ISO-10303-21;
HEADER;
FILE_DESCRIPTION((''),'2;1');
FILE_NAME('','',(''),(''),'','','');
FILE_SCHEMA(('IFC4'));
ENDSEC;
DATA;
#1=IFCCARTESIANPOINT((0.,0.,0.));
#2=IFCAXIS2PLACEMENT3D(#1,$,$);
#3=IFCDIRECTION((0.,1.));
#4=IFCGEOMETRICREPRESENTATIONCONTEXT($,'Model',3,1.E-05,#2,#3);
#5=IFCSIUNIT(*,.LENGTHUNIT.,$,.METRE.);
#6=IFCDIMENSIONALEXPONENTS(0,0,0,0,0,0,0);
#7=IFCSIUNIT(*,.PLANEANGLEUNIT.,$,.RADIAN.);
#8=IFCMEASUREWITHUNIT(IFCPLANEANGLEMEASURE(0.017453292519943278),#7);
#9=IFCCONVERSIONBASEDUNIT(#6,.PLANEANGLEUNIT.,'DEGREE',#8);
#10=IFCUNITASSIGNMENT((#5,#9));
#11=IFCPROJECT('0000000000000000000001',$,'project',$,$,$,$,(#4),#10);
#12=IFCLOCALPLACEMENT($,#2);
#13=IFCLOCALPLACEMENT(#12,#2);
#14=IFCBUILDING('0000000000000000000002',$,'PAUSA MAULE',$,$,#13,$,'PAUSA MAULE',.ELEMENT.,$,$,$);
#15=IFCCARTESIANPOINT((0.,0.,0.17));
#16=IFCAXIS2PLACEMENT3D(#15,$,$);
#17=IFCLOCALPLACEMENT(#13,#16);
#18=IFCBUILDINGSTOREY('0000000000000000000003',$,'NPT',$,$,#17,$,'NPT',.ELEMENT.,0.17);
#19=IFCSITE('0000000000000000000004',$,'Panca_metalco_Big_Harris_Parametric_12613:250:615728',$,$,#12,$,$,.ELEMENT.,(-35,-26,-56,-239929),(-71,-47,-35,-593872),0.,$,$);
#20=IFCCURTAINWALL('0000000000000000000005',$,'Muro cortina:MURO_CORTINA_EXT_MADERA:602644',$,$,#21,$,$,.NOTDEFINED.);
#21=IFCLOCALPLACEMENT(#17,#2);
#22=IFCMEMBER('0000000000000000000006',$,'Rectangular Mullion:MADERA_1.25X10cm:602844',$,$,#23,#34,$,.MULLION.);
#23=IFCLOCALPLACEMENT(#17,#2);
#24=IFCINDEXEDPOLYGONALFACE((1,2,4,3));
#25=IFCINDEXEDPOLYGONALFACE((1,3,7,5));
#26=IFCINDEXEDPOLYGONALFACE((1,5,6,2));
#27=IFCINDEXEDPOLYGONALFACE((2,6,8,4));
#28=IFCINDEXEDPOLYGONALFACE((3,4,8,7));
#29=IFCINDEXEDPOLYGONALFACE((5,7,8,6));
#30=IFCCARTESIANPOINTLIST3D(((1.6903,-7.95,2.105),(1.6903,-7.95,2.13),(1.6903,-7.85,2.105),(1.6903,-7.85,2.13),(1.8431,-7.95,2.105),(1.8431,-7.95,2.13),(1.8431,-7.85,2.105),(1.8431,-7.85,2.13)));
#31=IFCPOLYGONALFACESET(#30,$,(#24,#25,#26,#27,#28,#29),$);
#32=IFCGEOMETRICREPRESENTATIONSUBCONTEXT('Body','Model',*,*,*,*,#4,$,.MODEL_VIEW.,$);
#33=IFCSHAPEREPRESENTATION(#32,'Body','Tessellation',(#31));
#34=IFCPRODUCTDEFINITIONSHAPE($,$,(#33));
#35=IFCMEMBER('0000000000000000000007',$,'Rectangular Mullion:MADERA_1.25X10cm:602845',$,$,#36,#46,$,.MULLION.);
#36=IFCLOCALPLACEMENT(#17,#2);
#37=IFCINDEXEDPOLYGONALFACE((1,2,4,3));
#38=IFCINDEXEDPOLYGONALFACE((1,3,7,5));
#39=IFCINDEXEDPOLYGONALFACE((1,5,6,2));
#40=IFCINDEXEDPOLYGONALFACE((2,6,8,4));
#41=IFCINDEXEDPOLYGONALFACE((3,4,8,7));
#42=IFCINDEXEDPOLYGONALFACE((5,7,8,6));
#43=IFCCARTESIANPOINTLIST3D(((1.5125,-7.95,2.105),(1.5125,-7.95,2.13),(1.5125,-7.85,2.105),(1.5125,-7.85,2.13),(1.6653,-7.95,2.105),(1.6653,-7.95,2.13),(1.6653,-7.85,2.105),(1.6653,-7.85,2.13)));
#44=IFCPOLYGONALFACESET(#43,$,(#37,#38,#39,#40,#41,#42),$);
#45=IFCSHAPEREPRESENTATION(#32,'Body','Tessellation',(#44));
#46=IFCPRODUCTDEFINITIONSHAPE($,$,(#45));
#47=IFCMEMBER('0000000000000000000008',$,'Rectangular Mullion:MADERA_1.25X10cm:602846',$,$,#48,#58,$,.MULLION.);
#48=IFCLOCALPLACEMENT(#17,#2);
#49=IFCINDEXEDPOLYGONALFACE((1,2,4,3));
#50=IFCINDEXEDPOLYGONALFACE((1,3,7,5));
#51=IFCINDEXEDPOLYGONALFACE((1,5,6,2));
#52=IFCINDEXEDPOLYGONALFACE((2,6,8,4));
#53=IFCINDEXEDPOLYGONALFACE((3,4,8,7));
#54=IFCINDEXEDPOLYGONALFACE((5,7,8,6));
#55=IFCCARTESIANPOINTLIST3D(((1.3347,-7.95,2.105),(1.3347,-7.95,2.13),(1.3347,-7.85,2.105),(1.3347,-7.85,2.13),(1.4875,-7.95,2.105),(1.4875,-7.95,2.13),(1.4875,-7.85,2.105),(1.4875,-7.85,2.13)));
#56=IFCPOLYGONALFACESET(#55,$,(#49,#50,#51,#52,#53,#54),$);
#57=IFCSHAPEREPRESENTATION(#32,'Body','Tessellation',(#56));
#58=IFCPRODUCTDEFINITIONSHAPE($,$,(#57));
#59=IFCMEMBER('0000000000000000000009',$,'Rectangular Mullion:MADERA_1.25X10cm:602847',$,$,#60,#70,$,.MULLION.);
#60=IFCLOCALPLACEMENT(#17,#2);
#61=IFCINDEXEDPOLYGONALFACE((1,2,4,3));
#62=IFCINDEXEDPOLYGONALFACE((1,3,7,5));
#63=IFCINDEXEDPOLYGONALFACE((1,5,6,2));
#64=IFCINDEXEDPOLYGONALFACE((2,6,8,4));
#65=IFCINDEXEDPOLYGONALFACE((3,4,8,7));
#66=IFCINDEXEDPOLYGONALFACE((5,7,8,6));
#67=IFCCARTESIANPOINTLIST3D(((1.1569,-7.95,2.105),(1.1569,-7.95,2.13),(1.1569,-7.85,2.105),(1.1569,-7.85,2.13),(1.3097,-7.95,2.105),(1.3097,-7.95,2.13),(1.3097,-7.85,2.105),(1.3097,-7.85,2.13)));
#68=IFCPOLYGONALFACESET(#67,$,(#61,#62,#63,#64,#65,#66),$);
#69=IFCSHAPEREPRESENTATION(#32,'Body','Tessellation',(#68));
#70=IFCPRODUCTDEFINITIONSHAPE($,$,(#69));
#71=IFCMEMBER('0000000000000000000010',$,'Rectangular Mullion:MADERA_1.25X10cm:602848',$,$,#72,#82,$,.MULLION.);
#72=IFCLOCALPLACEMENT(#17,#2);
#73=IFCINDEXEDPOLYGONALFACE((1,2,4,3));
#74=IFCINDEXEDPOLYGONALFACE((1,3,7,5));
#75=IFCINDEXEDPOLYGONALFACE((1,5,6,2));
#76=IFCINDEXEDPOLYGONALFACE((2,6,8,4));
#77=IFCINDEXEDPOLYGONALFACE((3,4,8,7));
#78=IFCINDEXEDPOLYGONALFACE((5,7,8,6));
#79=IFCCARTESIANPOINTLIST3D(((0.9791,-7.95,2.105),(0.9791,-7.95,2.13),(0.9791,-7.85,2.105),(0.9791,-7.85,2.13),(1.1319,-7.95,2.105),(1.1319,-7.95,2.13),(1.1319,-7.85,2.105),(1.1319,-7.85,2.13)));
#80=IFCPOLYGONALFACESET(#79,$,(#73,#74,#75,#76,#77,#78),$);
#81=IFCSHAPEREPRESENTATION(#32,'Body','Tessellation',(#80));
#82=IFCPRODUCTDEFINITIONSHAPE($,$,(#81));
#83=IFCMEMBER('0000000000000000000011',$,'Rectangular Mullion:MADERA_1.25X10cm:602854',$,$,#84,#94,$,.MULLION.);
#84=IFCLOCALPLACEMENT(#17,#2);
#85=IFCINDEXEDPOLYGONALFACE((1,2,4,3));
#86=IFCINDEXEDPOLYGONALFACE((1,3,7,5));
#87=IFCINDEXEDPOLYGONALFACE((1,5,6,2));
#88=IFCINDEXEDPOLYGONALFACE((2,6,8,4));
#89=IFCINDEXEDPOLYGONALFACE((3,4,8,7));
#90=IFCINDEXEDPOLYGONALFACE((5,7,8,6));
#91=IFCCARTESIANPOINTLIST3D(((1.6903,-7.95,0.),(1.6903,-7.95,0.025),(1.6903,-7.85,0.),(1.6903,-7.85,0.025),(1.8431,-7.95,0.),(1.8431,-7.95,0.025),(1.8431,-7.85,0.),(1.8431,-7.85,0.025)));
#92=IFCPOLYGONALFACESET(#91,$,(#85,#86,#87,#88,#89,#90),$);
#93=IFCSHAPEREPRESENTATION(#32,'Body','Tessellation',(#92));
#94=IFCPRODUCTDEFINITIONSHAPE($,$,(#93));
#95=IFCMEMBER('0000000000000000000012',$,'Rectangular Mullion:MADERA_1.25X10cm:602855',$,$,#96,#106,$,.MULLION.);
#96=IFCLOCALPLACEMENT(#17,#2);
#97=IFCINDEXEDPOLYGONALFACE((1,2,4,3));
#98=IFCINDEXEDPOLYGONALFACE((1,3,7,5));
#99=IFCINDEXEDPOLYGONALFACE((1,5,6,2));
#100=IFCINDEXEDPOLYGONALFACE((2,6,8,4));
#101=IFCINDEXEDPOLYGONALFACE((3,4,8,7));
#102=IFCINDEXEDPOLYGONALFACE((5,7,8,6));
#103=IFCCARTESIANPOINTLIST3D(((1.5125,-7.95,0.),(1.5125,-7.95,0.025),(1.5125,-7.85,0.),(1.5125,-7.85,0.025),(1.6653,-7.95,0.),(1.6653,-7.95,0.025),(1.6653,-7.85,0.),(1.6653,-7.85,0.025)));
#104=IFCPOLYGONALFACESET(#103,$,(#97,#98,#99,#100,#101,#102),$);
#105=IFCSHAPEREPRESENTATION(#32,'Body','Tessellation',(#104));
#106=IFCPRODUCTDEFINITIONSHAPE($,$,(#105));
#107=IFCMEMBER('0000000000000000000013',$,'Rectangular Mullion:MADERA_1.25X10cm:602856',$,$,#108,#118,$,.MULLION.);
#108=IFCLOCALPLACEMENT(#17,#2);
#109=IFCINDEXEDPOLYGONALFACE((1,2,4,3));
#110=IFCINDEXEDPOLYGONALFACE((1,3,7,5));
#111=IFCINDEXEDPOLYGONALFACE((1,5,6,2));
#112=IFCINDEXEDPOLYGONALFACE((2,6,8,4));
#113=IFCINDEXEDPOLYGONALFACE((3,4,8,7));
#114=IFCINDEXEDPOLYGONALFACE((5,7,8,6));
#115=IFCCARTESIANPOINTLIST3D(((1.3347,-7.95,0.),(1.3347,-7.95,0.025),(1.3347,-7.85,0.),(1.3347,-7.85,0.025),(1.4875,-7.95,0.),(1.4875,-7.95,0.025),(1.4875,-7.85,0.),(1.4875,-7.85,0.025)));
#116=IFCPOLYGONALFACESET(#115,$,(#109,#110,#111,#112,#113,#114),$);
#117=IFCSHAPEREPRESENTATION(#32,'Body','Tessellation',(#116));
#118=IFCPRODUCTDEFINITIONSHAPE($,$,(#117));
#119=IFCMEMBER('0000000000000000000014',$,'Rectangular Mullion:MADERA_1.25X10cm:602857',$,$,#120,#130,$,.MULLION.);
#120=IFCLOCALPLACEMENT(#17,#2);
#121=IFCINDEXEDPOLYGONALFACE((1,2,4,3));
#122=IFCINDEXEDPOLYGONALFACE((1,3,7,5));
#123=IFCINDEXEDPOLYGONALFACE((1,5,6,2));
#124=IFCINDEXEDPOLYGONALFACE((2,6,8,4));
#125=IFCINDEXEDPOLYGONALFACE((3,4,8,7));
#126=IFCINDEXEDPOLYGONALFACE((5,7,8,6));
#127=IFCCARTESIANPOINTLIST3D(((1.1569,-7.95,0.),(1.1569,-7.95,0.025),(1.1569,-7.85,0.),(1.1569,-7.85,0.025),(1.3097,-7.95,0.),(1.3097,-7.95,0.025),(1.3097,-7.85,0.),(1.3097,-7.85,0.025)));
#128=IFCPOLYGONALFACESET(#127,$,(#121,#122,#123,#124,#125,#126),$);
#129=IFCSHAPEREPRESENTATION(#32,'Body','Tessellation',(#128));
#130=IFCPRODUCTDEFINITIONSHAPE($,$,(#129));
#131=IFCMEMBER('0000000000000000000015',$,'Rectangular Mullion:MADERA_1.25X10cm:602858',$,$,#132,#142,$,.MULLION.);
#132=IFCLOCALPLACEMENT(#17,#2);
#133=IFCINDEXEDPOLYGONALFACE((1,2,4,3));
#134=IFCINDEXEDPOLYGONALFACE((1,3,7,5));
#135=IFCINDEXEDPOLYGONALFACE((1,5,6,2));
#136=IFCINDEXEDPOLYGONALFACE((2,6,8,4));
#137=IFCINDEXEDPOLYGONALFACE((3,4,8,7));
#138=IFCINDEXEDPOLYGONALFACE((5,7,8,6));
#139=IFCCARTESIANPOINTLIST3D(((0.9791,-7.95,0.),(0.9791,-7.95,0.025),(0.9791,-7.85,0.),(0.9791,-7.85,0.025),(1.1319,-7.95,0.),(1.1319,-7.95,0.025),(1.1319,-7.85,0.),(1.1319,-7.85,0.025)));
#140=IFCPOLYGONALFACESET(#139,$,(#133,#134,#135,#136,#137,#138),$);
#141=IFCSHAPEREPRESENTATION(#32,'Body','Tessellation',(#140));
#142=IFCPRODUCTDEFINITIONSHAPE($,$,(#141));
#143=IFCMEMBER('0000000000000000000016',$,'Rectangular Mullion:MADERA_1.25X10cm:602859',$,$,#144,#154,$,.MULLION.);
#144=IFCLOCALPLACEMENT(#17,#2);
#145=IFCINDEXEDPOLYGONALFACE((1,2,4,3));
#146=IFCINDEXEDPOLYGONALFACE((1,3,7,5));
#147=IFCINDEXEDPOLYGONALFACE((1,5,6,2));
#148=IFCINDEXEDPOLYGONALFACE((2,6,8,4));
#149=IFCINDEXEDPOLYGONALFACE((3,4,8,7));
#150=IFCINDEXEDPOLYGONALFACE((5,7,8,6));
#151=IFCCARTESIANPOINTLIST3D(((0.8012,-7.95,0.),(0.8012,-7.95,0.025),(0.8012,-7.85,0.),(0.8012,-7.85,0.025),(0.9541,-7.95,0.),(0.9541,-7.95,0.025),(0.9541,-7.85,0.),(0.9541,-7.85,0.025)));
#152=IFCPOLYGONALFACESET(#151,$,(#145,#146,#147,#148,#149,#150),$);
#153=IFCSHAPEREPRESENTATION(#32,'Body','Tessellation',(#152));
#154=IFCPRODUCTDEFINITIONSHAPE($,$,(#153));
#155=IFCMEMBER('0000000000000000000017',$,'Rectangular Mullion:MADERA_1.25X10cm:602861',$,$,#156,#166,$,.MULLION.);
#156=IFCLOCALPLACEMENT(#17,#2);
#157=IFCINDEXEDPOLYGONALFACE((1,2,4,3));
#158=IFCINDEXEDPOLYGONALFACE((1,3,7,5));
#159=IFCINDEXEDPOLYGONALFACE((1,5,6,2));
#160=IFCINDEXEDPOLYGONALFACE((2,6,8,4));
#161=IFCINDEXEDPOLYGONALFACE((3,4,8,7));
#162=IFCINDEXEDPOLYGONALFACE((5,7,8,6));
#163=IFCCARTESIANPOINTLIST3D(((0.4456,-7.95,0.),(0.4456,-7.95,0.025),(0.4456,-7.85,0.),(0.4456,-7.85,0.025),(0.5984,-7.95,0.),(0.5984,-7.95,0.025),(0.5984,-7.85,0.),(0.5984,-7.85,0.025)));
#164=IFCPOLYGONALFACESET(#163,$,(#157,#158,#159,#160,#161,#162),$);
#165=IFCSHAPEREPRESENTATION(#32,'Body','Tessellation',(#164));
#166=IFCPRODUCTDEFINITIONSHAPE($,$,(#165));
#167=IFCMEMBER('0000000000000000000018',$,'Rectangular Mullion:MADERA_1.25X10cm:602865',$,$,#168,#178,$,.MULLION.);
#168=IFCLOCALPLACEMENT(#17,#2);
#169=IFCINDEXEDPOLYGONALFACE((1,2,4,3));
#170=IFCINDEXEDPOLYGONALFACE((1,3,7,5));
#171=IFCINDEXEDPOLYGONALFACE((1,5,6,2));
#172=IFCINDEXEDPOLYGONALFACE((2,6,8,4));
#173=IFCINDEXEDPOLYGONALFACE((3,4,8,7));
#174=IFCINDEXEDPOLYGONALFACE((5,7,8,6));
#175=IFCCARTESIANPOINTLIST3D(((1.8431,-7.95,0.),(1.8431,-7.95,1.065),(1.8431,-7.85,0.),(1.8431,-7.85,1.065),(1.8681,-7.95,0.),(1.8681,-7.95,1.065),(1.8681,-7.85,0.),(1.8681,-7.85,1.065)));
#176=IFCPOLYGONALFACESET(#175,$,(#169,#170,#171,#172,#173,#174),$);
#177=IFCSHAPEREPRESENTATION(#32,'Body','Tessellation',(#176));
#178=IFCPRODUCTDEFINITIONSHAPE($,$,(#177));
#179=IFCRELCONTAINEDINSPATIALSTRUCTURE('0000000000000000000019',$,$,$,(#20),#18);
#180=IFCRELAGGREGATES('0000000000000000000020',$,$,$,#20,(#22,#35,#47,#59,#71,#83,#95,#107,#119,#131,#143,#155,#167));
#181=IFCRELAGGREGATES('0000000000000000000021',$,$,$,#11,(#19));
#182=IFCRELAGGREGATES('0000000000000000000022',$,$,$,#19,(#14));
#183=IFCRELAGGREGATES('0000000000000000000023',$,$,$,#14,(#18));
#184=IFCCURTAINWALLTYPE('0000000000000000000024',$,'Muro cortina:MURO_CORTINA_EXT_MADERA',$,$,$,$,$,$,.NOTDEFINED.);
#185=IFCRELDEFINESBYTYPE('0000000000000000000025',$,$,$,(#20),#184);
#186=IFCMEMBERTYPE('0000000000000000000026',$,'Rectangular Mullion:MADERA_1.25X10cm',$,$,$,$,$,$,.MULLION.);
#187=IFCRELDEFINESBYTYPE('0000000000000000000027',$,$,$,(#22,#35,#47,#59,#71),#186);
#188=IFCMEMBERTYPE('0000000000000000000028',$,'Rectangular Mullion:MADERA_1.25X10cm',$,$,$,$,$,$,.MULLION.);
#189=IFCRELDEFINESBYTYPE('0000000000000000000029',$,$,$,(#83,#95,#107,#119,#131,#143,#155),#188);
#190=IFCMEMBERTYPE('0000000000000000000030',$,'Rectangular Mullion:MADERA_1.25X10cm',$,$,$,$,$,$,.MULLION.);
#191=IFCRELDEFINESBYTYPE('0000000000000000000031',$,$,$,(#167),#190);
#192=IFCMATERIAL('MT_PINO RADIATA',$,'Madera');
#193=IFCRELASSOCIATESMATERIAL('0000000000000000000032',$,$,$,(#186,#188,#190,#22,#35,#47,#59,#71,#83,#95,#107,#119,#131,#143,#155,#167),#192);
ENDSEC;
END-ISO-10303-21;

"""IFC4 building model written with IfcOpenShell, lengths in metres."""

from ifc_helpers import new_model, entity, si_unit, converted_unit, direction, frame, frame_2d, origin, place, context, subcontext, project, spatial, rectangle, extrude, source, transform, mapped, material, material_profile, profile_set, profile_usage, type_object, type_shapes, element, aggregate, save


model = new_model("IFC4")

# Units and contexts
model_context = context("Model", 3, precision=1e-05, world=origin(), true_north=direction((0.0, 1.0)))
body_context = subcontext(model_context, "Body", "Model", "MODEL_VIEW")
ifc_project = project(units=[si_unit("LENGTHUNIT", "METRE"), converted_unit("PLANEANGLEUNIT", "DEGREE", entity("IfcPlaneAngleMeasure", 0.017453292519943278), si_unit("PLANEANGLEUNIT", "RADIAN"), dimensions=[0, 0, 0, 0, 0, 0, 0])], contexts=[model_context])

# Site, building, storey
site_placement = place(None, origin())
site = spatial("IfcSite", under=ifc_project, at=site_placement, Name="Panca_metalco_Big_Harris_Parametric_12613:250:615728", CompositionType="ELEMENT", RefLatitude=(-35, -26, -56, -239929), RefLongitude=(-71, -47, -35, -593872), RefElevation=0.0)
building_placement = place(site_placement, origin())
building = spatial("IfcBuilding", under=site, at=building_placement, Name="PAUSA MAULE", LongName="PAUSA MAULE", CompositionType="ELEMENT")
storey_placement = place(building_placement, frame((0.0, 0.0, 0.17)))
storey = spatial("IfcBuildingStorey", under=building, at=storey_placement, Name="NPT", LongName="NPT", CompositionType="ELEMENT", Elevation=0.17)

# Curtain wall, members
curtain_wall_type = type_object("IfcCurtainWallType", Name="Muro cortina:MURO_CORTINA_EXT_MADERA", PredefinedType="NOTDEFINED")
curtain_wall_placement = place(storey_placement, frame((0.0, 0.0, -0.17)))
curtain_wall = element("IfcCurtainWall", 1, at=curtain_wall_placement, inside=storey, type_object=curtain_wall_type, Name="Muro cortina:MURO_CORTINA_EXT_MADERA:602644", PredefinedType="NOTDEFINED")
ifc_material = material(Name="MT_PINO RADIATA", Category="Madera")
ifc_material_profile = material_profile(ifc_material, rectangle(XDim=0.025, YDim=0.1, at=frame_2d((0.0, 0.0), x_axis=(1.0, 0.0))), Name="MADERA_1.25X10cm")
ifc_profile_set = profile_set([ifc_material_profile], Name="MADERA_1.25X10cm")
ifc_profile_usage = profile_usage(ifc_profile_set)
member_type_1 = type_object("IfcMemberType", Name="Rectangular Mullion:MADERA_1.25X10cm", PredefinedType="MULLION", material=ifc_profile_set)
shared_shape_1 = source(origin(), body_context, "Body", "SweptSolid", [
    extrude(rectangle(XDim=0.025, YDim=0.1, at=frame_2d((0.0, 0.0), x_axis=(1.0, 0.0))), frame((-0.0125, 0.0, -0.1528), z_axis=(0.0, 0.0, 1.0), x_axis=(-1.0, 0.0, 0.0)), (0.0, 0.0, 1.0), 0.1528),
])
type_shapes(member_type_1, [shared_shape_1])
member_1_placement = place(curtain_wall_placement, frame((1.6903, -7.9, 2.3), z_axis=(-1.0, 0.0, 0.0), x_axis=(0.0, 0.0, 1.0)))
member_1 = element("IfcMember", 2, at=member_1_placement, type_object=member_type_1, material=ifc_profile_usage, Name="Rectangular Mullion:MADERA_1.25X10cm:602844", PredefinedType="MULLION", context=body_context, shape_type="MappedRepresentation", body=[
    mapped(shared_shape_1, transform((0.0, 0.0, 0.0), scale=1.0)),
])
member_2_placement = place(curtain_wall_placement, frame((1.5125, -7.9, 2.3), z_axis=(-1.0, 0.0, 0.0), x_axis=(0.0, 0.0, 1.0)))
member_2 = element("IfcMember", 3, at=member_2_placement, type_object=member_type_1, material=ifc_profile_usage, Name="Rectangular Mullion:MADERA_1.25X10cm:602845", PredefinedType="MULLION", context=body_context, shape_type="MappedRepresentation", body=[
    mapped(shared_shape_1, transform((0.0, 0.0, 0.0), scale=1.0)),
])
member_3_placement = place(curtain_wall_placement, frame((1.3347, -7.9, 2.3), z_axis=(-1.0, 0.0, 0.0), x_axis=(0.0, 0.0, 1.0)))
member_3 = element("IfcMember", 4, at=member_3_placement, type_object=member_type_1, material=ifc_profile_usage, Name="Rectangular Mullion:MADERA_1.25X10cm:602846", PredefinedType="MULLION", context=body_context, shape_type="MappedRepresentation", body=[
    mapped(shared_shape_1, transform((0.0, 0.0, 0.0), scale=1.0)),
])
member_4_placement = place(curtain_wall_placement, frame((1.1569, -7.9, 2.3), z_axis=(-1.0, 0.0, 0.0), x_axis=(0.0, 0.0, 1.0)))
member_4 = element("IfcMember", 5, at=member_4_placement, type_object=member_type_1, material=ifc_profile_usage, Name="Rectangular Mullion:MADERA_1.25X10cm:602847", PredefinedType="MULLION", context=body_context, shape_type="MappedRepresentation", body=[
    mapped(shared_shape_1, transform((0.0, 0.0, 0.0), scale=1.0)),
])
member_5_placement = place(curtain_wall_placement, frame((0.9791, -7.9, 2.3), z_axis=(-1.0, 0.0, 0.0), x_axis=(0.0, 0.0, 1.0)))
member_5 = element("IfcMember", 6, at=member_5_placement, type_object=member_type_1, material=ifc_profile_usage, Name="Rectangular Mullion:MADERA_1.25X10cm:602848", PredefinedType="MULLION", context=body_context, shape_type="MappedRepresentation", body=[
    mapped(shared_shape_1, transform((0.0, 0.0, 0.0), scale=1.0)),
])
member_type_2 = type_object("IfcMemberType", Name="Rectangular Mullion:MADERA_1.25X10cm", PredefinedType="MULLION", material=ifc_profile_set)
shared_shape_2 = source(origin(), body_context, "Body", "SweptSolid", [
    extrude(rectangle(XDim=0.025, YDim=0.1, at=frame_2d((0.0, 0.0), x_axis=(1.0, 0.0))), frame((-0.0125, 0.0, -0.1528), z_axis=(0.0, 0.0, 1.0), x_axis=(-1.0, 0.0, 0.0)), (0.0, 0.0, 1.0), 0.1528),
])
type_shapes(member_type_2, [shared_shape_2])
member_6_placement = place(curtain_wall_placement, frame((1.8431, -7.9, 0.17), z_axis=(1.0, 0.0, 0.0), x_axis=(0.0, 0.0, -1.0)))
member_6 = element("IfcMember", 7, at=member_6_placement, type_object=member_type_2, material=ifc_profile_usage, Name="Rectangular Mullion:MADERA_1.25X10cm:602854", PredefinedType="MULLION", context=body_context, shape_type="MappedRepresentation", body=[
    mapped(shared_shape_2, transform((0.0, 0.0, 0.0), scale=1.0)),
])
member_7_placement = place(curtain_wall_placement, frame((1.6653, -7.9, 0.17), z_axis=(1.0, 0.0, 0.0), x_axis=(0.0, 0.0, -1.0)))
member_7 = element("IfcMember", 8, at=member_7_placement, type_object=member_type_2, material=ifc_profile_usage, Name="Rectangular Mullion:MADERA_1.25X10cm:602855", PredefinedType="MULLION", context=body_context, shape_type="MappedRepresentation", body=[
    mapped(shared_shape_2, transform((0.0, 0.0, 0.0), scale=1.0)),
])
member_8_placement = place(curtain_wall_placement, frame((1.4875, -7.9, 0.17), z_axis=(1.0, 0.0, 0.0), x_axis=(0.0, 0.0, -1.0)))
member_8 = element("IfcMember", 9, at=member_8_placement, type_object=member_type_2, material=ifc_profile_usage, Name="Rectangular Mullion:MADERA_1.25X10cm:602856", PredefinedType="MULLION", context=body_context, shape_type="MappedRepresentation", body=[
    mapped(shared_shape_2, transform((0.0, 0.0, 0.0), scale=1.0)),
])
member_9_placement = place(curtain_wall_placement, frame((1.3097, -7.9, 0.17), z_axis=(1.0, 0.0, 0.0), x_axis=(0.0, 0.0, -1.0)))
member_9 = element("IfcMember", 10, at=member_9_placement, type_object=member_type_2, material=ifc_profile_usage, Name="Rectangular Mullion:MADERA_1.25X10cm:602857", PredefinedType="MULLION", context=body_context, shape_type="MappedRepresentation", body=[
    mapped(shared_shape_2, transform((0.0, 0.0, 0.0), scale=1.0)),
])
member_10_placement = place(curtain_wall_placement, frame((1.1319, -7.9, 0.17), z_axis=(1.0, 0.0, 0.0), x_axis=(0.0, 0.0, -1.0)))
member_10 = element("IfcMember", 11, at=member_10_placement, type_object=member_type_2, material=ifc_profile_usage, Name="Rectangular Mullion:MADERA_1.25X10cm:602858", PredefinedType="MULLION", context=body_context, shape_type="MappedRepresentation", body=[
    mapped(shared_shape_2, transform((0.0, 0.0, 0.0), scale=1.0)),
])
member_11_placement = place(curtain_wall_placement, frame((0.9541, -7.9, 0.17), z_axis=(1.0, 0.0, 0.0), x_axis=(0.0, 0.0, -1.0)))
member_11 = element("IfcMember", 12, at=member_11_placement, type_object=member_type_2, material=ifc_profile_usage, Name="Rectangular Mullion:MADERA_1.25X10cm:602859", PredefinedType="MULLION", context=body_context, shape_type="MappedRepresentation", body=[
    mapped(shared_shape_2, transform((0.0, 0.0, 0.0), scale=1.0)),
])
member_12_placement = place(curtain_wall_placement, frame((0.5984, -7.9, 0.17), z_axis=(1.0, 0.0, 0.0), x_axis=(0.0, 0.0, -1.0)))
member_12 = element("IfcMember", 13, at=member_12_placement, type_object=member_type_2, material=ifc_profile_usage, Name="Rectangular Mullion:MADERA_1.25X10cm:602861", PredefinedType="MULLION", context=body_context, shape_type="MappedRepresentation", body=[
    mapped(shared_shape_2, transform((0.0, 0.0, 0.0), scale=1.0)),
])
member_type_3 = type_object("IfcMemberType", Name="Rectangular Mullion:MADERA_1.25X10cm", PredefinedType="MULLION", material=ifc_profile_set)
shared_shape_3 = source(origin(), body_context, "Body", "SweptSolid", [
    extrude(rectangle(XDim=0.025, YDim=0.1, at=frame_2d((0.0, 0.0), x_axis=(1.0, 0.0))), frame((0.0, 0.0, -1.065), z_axis=(0.0, 0.0, 1.0), x_axis=(-1.0, 0.0, 0.0)), (0.0, 0.0, 1.0), 1.065),
])
type_shapes(member_type_3, [shared_shape_3])
member_13_placement = place(curtain_wall_placement, frame((1.8556, -7.9, 0.17), z_axis=(0.0, 0.0, -1.0), x_axis=(-1.0, 0.0, 0.0)))
member_13 = element("IfcMember", 14, at=member_13_placement, type_object=member_type_3, material=ifc_profile_usage, Name="Rectangular Mullion:MADERA_1.25X10cm:602865", PredefinedType="MULLION", context=body_context, shape_type="MappedRepresentation", body=[
    mapped(shared_shape_3, transform((0.0, 0.0, 0.0), scale=1.0)),
])
aggregate(curtain_wall, [member_1, member_2, member_3, member_4, member_5, member_6, member_7, member_8, member_9, member_10, member_11, member_12, member_13])

save(model, "model.ifc")
